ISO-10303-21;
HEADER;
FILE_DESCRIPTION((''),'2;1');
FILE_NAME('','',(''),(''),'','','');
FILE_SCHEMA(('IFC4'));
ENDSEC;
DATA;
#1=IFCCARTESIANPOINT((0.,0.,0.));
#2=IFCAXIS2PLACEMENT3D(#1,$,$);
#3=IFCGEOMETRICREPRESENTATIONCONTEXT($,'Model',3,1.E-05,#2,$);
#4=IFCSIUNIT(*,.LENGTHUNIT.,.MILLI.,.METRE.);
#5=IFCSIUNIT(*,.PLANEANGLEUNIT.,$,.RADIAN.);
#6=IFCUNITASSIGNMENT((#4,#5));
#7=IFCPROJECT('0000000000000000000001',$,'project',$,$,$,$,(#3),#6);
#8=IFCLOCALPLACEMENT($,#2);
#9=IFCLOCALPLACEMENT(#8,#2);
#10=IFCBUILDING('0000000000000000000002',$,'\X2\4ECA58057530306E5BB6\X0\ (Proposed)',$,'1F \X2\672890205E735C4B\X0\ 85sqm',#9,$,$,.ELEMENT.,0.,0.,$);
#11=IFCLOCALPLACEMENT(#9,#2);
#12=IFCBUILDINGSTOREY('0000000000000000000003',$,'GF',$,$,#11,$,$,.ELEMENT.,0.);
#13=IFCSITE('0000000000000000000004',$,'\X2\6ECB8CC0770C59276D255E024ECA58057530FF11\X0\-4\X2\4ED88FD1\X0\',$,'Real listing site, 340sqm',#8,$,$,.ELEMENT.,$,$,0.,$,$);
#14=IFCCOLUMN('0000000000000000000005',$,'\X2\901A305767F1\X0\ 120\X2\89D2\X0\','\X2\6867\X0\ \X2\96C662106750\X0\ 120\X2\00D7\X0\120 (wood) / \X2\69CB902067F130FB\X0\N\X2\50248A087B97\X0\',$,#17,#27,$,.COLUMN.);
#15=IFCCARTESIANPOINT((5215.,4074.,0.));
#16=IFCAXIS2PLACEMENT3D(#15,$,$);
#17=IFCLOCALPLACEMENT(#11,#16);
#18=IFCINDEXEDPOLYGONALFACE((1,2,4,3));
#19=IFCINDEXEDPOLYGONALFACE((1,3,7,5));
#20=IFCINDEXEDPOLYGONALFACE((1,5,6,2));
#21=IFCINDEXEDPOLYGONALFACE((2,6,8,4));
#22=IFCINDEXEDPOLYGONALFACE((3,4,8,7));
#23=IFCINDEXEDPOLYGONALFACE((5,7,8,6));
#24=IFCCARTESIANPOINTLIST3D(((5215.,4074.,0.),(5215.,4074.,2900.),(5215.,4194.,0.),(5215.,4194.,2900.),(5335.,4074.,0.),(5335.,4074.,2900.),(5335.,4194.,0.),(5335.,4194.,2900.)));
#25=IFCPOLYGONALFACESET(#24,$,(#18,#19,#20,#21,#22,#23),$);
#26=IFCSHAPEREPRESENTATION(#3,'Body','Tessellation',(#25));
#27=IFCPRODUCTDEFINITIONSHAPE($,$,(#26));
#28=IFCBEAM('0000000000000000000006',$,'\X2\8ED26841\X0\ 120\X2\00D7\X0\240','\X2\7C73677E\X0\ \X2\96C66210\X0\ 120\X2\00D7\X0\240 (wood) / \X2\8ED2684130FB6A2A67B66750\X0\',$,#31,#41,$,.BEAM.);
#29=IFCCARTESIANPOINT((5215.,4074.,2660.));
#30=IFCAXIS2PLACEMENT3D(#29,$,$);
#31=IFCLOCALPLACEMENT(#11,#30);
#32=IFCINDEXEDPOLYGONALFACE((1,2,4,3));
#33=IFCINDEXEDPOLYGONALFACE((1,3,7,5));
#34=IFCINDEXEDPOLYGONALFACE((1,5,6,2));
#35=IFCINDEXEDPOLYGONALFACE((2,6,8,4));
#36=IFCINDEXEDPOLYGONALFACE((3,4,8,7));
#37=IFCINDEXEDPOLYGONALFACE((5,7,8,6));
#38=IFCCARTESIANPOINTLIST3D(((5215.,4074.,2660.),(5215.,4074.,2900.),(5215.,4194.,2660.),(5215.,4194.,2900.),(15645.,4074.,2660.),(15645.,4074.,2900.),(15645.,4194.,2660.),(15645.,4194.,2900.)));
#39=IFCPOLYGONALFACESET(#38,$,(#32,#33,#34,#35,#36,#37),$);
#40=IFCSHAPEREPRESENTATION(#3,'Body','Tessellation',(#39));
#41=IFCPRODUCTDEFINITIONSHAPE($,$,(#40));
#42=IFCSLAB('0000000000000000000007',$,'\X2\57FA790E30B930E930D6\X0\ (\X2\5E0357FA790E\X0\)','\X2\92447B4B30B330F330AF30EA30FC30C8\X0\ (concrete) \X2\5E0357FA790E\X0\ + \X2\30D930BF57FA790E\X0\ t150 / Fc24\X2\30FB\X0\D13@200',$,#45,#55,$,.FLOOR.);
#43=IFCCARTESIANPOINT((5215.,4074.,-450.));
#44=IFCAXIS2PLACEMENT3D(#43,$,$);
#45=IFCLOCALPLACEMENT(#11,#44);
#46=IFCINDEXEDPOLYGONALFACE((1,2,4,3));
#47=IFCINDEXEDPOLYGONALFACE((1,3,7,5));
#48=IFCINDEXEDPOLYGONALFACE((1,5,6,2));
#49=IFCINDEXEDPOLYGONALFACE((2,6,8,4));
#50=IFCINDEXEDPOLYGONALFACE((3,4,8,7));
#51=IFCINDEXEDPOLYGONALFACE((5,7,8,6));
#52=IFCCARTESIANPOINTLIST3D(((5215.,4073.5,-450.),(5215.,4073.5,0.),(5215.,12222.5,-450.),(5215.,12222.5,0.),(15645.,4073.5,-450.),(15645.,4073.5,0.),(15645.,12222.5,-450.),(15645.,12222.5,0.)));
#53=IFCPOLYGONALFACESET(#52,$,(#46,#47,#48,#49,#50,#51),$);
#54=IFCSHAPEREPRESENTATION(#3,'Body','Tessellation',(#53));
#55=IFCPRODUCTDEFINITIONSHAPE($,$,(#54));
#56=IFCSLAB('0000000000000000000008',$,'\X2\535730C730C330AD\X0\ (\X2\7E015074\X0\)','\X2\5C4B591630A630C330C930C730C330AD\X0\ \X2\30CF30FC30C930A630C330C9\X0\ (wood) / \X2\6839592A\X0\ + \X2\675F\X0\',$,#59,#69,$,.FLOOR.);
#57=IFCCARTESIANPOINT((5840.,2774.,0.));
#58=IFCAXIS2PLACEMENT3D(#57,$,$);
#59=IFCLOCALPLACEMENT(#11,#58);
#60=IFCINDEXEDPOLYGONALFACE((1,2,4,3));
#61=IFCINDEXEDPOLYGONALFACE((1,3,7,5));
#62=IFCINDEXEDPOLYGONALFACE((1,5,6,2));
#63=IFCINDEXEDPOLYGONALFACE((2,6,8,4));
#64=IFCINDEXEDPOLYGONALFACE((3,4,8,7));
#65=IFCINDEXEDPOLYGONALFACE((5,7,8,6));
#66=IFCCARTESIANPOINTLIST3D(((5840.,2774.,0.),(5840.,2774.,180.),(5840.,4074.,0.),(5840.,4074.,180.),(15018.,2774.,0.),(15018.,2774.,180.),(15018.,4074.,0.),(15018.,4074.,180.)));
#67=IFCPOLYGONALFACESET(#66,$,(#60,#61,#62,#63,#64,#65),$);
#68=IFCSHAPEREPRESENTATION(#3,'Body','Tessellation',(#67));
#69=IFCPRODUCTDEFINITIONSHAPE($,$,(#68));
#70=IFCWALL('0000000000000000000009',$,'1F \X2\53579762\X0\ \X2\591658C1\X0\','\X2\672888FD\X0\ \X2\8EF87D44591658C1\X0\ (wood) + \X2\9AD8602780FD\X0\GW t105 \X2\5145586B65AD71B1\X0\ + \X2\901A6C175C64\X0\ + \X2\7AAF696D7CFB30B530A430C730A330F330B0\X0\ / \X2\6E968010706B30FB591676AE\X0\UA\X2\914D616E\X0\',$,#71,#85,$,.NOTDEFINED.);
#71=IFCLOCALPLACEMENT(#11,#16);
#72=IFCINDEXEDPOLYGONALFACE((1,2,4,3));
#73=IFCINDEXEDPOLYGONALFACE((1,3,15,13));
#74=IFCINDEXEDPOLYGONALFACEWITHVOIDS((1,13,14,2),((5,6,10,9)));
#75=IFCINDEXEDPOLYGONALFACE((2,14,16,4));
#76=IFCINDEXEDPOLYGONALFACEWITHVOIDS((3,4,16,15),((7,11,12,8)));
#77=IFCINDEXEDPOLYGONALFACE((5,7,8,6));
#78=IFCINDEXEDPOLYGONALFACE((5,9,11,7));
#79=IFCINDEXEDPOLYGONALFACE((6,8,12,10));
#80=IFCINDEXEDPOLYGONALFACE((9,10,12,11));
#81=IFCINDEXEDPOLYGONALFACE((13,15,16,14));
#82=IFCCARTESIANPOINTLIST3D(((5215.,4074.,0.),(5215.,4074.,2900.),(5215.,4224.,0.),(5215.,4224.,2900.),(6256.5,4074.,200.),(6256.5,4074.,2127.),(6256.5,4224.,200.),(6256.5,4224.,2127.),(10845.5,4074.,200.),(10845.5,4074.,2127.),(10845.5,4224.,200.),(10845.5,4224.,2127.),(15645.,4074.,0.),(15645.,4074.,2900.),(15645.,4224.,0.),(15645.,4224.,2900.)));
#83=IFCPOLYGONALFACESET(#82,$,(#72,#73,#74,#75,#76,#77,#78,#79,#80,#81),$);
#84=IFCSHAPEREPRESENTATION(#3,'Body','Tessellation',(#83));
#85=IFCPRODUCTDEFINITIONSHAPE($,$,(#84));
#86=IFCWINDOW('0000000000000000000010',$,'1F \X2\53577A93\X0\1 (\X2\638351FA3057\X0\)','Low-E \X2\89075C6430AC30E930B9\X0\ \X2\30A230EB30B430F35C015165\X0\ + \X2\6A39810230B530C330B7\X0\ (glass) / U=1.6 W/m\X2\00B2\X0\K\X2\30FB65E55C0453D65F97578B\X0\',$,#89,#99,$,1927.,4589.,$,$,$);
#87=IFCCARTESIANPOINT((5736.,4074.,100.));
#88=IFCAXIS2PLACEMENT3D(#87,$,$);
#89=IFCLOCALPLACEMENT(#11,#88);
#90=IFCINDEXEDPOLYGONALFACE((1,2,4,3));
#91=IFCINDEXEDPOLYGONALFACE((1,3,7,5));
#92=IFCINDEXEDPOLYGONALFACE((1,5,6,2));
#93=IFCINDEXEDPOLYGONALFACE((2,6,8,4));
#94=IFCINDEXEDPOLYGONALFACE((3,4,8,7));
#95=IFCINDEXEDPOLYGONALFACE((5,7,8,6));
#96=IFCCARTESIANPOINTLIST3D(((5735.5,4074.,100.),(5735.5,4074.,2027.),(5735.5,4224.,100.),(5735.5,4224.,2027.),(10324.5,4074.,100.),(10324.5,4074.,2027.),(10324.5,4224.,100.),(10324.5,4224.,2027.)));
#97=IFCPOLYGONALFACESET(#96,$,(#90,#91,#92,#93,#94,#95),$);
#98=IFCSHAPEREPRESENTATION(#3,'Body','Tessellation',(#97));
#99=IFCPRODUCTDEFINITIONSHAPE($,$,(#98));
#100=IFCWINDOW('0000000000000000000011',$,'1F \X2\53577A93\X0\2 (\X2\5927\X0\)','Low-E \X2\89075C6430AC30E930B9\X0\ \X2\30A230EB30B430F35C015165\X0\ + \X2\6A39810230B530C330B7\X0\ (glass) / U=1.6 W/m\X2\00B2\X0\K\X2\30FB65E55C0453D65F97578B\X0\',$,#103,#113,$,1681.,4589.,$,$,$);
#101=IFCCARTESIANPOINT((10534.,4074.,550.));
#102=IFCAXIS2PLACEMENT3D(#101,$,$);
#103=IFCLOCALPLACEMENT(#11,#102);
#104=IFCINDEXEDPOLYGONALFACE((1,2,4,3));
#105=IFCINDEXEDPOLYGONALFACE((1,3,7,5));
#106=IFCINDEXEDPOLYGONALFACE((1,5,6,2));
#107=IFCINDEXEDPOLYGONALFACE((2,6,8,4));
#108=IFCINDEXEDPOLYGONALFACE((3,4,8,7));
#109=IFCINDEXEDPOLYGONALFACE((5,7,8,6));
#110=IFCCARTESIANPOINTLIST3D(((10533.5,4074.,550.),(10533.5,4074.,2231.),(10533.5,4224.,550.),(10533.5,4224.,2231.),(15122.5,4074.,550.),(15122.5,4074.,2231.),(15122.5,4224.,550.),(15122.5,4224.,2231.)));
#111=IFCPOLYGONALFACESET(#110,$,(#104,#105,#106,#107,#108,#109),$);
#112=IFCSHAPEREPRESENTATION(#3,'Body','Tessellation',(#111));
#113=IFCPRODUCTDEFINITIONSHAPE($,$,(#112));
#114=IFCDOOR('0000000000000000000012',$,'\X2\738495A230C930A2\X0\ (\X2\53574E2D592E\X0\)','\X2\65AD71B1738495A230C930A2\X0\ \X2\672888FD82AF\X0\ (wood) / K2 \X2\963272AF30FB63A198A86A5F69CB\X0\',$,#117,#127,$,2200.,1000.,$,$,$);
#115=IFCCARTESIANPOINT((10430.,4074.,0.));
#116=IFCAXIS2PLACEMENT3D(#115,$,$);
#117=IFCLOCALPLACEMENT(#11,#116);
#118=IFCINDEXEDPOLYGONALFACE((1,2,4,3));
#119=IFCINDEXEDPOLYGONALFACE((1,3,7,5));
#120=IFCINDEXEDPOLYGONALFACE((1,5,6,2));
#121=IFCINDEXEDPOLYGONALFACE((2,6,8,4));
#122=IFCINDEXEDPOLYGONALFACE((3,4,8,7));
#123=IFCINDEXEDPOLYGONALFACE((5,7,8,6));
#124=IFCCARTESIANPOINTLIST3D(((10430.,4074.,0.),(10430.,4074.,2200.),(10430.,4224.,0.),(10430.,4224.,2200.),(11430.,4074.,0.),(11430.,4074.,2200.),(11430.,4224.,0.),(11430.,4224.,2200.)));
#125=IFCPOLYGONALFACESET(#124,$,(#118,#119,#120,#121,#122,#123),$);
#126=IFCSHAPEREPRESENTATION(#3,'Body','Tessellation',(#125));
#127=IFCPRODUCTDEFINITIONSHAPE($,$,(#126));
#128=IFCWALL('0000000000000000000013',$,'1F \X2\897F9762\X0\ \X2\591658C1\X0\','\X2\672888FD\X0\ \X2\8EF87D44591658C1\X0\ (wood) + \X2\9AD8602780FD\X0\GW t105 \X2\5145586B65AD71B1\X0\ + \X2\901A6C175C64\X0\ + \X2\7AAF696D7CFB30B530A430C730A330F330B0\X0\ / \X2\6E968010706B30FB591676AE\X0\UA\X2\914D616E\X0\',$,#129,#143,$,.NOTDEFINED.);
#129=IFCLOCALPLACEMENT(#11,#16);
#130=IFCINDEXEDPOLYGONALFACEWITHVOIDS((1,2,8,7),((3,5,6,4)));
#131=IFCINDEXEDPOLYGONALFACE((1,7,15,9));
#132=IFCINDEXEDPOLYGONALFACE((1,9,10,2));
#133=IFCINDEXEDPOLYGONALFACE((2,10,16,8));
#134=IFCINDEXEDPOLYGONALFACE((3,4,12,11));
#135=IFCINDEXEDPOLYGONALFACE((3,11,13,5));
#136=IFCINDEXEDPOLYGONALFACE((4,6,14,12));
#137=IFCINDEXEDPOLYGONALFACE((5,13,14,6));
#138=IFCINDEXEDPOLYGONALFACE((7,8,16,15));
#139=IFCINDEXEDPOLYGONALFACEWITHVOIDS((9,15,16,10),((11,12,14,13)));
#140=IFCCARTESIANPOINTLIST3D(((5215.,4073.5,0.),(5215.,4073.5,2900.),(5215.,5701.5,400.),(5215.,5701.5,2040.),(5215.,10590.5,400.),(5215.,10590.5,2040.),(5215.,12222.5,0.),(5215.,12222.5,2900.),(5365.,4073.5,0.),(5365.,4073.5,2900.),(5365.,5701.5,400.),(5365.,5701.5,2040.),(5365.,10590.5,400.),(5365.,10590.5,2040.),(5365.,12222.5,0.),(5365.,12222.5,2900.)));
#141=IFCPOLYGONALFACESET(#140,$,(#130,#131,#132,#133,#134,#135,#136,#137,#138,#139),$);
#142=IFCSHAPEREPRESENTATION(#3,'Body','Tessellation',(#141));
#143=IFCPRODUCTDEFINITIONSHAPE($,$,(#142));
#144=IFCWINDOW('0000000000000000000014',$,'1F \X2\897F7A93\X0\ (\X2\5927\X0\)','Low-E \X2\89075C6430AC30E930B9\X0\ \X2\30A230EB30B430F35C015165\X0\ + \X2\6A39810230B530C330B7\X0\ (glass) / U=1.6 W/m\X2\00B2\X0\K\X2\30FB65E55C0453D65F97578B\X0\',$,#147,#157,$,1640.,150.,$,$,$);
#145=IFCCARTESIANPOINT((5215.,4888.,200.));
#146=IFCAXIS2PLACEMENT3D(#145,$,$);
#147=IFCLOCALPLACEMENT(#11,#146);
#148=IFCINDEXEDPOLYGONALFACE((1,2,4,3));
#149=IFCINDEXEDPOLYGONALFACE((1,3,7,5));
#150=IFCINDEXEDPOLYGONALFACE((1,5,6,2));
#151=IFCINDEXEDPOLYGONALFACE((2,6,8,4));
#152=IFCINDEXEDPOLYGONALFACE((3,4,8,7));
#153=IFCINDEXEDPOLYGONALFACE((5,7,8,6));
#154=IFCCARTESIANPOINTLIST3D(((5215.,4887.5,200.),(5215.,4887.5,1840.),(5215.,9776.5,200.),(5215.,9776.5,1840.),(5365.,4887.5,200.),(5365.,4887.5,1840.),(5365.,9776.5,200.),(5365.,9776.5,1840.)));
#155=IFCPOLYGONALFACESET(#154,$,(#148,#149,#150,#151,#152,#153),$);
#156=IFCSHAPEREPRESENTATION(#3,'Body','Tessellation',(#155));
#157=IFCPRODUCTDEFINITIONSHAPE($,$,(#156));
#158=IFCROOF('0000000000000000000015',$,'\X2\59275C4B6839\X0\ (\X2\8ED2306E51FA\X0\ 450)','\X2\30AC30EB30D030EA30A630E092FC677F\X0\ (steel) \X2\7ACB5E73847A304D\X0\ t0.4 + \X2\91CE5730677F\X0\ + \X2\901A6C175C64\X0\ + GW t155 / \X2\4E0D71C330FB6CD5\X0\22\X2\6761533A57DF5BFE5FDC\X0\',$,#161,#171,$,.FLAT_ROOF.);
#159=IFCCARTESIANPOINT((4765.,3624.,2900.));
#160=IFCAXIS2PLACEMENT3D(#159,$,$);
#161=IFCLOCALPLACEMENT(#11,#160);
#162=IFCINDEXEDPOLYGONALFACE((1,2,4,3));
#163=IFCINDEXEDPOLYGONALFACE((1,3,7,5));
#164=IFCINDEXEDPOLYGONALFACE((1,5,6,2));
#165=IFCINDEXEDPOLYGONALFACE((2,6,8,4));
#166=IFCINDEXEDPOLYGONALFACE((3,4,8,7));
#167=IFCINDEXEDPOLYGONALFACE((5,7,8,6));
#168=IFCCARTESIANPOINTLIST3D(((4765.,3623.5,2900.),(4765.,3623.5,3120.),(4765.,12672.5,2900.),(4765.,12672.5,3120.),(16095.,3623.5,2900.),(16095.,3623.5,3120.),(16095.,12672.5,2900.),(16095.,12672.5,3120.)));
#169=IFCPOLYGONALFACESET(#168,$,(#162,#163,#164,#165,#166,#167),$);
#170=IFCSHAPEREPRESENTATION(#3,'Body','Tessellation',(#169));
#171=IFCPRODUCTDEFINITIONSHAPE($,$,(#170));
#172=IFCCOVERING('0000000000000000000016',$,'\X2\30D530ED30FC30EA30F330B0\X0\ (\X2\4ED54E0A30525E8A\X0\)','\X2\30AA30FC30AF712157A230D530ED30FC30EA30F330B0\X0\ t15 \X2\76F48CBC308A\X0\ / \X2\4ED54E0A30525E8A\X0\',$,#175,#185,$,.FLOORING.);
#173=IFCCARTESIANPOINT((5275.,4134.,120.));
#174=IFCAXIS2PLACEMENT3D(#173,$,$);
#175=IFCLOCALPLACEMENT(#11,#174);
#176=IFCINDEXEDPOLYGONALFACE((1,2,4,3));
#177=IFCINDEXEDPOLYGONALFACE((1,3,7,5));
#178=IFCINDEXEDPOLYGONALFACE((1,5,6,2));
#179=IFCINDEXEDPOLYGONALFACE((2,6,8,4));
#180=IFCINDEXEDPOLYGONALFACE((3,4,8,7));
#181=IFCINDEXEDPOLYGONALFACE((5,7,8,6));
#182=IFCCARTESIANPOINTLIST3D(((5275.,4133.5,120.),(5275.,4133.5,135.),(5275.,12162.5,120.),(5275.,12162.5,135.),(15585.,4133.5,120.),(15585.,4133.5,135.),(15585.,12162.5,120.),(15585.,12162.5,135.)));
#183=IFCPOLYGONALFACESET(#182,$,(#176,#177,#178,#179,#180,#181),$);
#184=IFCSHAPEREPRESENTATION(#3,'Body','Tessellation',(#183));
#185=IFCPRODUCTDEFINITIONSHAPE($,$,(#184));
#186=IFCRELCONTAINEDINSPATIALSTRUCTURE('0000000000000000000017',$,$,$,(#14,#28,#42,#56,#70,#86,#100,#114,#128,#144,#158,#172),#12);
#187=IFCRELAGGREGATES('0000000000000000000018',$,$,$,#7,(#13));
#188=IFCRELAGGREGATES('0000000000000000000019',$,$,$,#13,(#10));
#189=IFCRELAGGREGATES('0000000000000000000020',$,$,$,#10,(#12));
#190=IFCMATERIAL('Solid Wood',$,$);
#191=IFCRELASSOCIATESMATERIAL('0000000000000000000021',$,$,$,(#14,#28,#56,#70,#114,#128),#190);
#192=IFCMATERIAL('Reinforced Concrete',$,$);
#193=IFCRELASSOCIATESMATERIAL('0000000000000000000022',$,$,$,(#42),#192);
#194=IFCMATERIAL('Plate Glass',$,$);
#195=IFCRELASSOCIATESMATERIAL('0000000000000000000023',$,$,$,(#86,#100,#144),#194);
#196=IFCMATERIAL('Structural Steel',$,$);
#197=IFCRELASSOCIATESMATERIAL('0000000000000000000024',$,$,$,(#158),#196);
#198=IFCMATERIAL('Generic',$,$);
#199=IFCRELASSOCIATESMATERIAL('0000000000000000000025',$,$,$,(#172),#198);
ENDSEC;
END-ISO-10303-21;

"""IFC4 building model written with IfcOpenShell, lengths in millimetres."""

from ifc_helpers import new_model, si_unit, frame, frame_2d, origin, place, context, project, spatial, rectangle, extrude, material, element, fill, save


model = new_model("IFC4")

# Units and contexts
model_context = context("Model", 3, precision=1e-05, world=origin())
ifc_project = project(units=[si_unit("LENGTHUNIT", "METRE", prefix="MILLI"), si_unit("PLANEANGLEUNIT", "RADIAN")], contexts=[model_context])

# Site, building, storey
site_placement = place(None, origin())
site = spatial("IfcSite", under=ifc_project, at=site_placement, Name="滋賀県大津市今堅田１-4付近", ObjectType="Real listing site, 340sqm", CompositionType="ELEMENT", RefElevation=0.0)
building_placement = place(site_placement, origin())
building = spatial("IfcBuilding", under=site, at=building_placement, Name="今堅田の家 (Proposed)", ObjectType="1F 木造平屋 85sqm", CompositionType="ELEMENT", ElevationOfRefHeight=0.0, ElevationOfTerrain=0.0)
storey_placement = place(building_placement, origin())
storey = spatial("IfcBuildingStorey", under=building, at=storey_placement, Name="GF", CompositionType="ELEMENT", Elevation=0.0)

# Column
ifc_material_1 = material(Name="Solid Wood")
column_1_placement = place(storey_placement, frame((5215.0, 4074.0, 0.0)))
element("IfcColumn", 1, at=column_1_placement, inside=storey, material=ifc_material_1, Name="通し柱 120角", Description="桧 集成材 120×120 (wood) / 構造柱・N値計算", PredefinedType="COLUMN", context=model_context, shape_type="SweptSolid", body=[
    extrude(rectangle(XDim=120.0, YDim=120.0, at=frame_2d((60.0, 60.0))), frame((5215.0, 4074.0, 0.0)), (0.0, 0.0, 1.0), 2900.0),
])

# Beam
beam_1_placement = place(storey_placement, frame((5215.0, 4074.0, 2660.0)))
element("IfcBeam", 2, at=beam_1_placement, inside=storey, material=ifc_material_1, Name="軒桁 120×240", Description="米松 集成 120×240 (wood) / 軒桁・横架材", PredefinedType="BEAM", context=model_context, shape_type="SweptSolid", body=[
    extrude(rectangle(XDim=10430.0, YDim=120.0, at=frame_2d((5215.0, 60.0))), frame((5215.0, 4074.0, 2660.0)), (0.0, 0.0, 1.0), 240.0),
])

# Slabs
ifc_material_2 = material(Name="Reinforced Concrete")
slab_1_placement = place(storey_placement, frame((5215.0, 4074.0, -450.0)))
element("IfcSlab", 3, at=slab_1_placement, inside=storey, material=ifc_material_2, Name="基礎スラブ (布基礎)", Description="鉄筋コンクリート (concrete) 布基礎 + ベタ基礎 t150 / Fc24・D13@200", PredefinedType="FLOOR", context=model_context, shape_type="SweptSolid", body=[
    extrude(rectangle(XDim=10430.0, YDim=8149.0, at=frame_2d((5215.0, 4074.0))), frame((5215.0, 4074.0, -450.0)), (0.0, 0.0, 1.0), 450.0),
])
slab_2_placement = place(storey_placement, frame((5840.0, 2774.0, 0.0)))
element("IfcSlab", 4, at=slab_2_placement, inside=storey, material=ifc_material_1, Name="南デッキ (縁側)", Description="屋外ウッドデッキ ハードウッド (wood) / 根太 + 束", PredefinedType="FLOOR", context=model_context, shape_type="SweptSolid", body=[
    extrude(rectangle(XDim=9178.0, YDim=1300.0, at=frame_2d((4589.0, 650.0))), frame((5840.0, 2774.0, 0.0)), (0.0, 0.0, 1.0), 180.0),
])

# Wall, openings, windows, door
wall_1_placement = place(storey_placement, frame((5215.0, 4074.0, 0.0)))
wall_1 = element("IfcWall", 5, at=wall_1_placement, inside=storey, material=ifc_material_1, Name="1F 南面 外壁", Description="木製 軸組外壁 (wood) + 高性能GW t105 充填断熱 + 通気層 + 窯業系サイディング / 準耐火・外皮UA配慮", PredefinedType="NOTDEFINED", context=model_context, shape_type="SweptSolid", body=[
    extrude(rectangle(XDim=10430.0, YDim=150.0, at=frame_2d((5215.0, 75.0))), frame((5215.0, 4074.0, 0.0)), (0.0, 0.0, 1.0), 2900.0),
])
opening_1_placement = place(storey_placement, frame((5736.0, 4074.0, 100.0)))
opening_1 = element("IfcOpeningElement", 6, at=opening_1_placement, cuts=wall_1, PredefinedType="NOTDEFINED", context=model_context, shape_type="SweptSolid", body=[
    extrude(rectangle(XDim=4589.0, YDim=150.0, at=frame_2d((2294.0, 75.0))), frame((5736.0, 4074.0, 100.0)), (0.0, 0.0, 1.0), 1927.0),
])
opening_2_placement = place(storey_placement, frame((10534.0, 4074.0, 550.0)))
opening_2 = element("IfcOpeningElement", 7, at=opening_2_placement, cuts=wall_1, PredefinedType="NOTDEFINED", context=model_context, shape_type="SweptSolid", body=[
    extrude(rectangle(XDim=4589.0, YDim=150.0, at=frame_2d((2294.0, 75.0))), frame((10534.0, 4074.0, 550.0)), (0.0, 0.0, 1.0), 1681.0),
])
opening_3_placement = place(storey_placement, frame((10430.0, 4074.0, 0.0)))
opening_3 = element("IfcOpeningElement", 8, at=opening_3_placement, cuts=wall_1, PredefinedType="NOTDEFINED", context=model_context, shape_type="SweptSolid", body=[
    extrude(rectangle(XDim=1000.0, YDim=150.0, at=frame_2d((500.0, 75.0))), frame((10430.0, 4074.0, 0.0)), (0.0, 0.0, 1.0), 2200.0),
])
ifc_material_3 = material(Name="Plate Glass")
window_1_placement = place(storey_placement, frame((5736.0, 4074.0, 100.0)))
window_1 = element("IfcWindow", 9, at=window_1_placement, inside=storey, material=ifc_material_3, Name="1F 南窓1 (掃出し)", Description="Low-E 複層ガラス アルゴン封入 + 樹脂サッシ (glass) / U=1.6 W/m²K・日射取得型", OverallHeight=1927.0, OverallWidth=4589.0, context=model_context, shape_type="SweptSolid", body=[
    extrude(rectangle(XDim=4589.0, YDim=150.0, at=frame_2d((2294.0, 75.0))), frame((5736.0, 4074.0, 100.0)), (0.0, 0.0, 1.0), 1927.0),
])
fill(opening_1, window_1)
window_2_placement = place(storey_placement, frame((10534.0, 4074.0, 550.0)))
window_2 = element("IfcWindow", 10, at=window_2_placement, inside=storey, material=ifc_material_3, Name="1F 南窓2 (大)", Description="Low-E 複層ガラス アルゴン封入 + 樹脂サッシ (glass) / U=1.6 W/m²K・日射取得型", OverallHeight=1681.0, OverallWidth=4589.0, context=model_context, shape_type="SweptSolid", body=[
    extrude(rectangle(XDim=4589.0, YDim=150.0, at=frame_2d((2294.0, 75.0))), frame((10534.0, 4074.0, 550.0)), (0.0, 0.0, 1.0), 1681.0),
])
fill(opening_2, window_2)
door_placement = place(storey_placement, frame((10430.0, 4074.0, 0.0)))
door = element("IfcDoor", 11, at=door_placement, inside=storey, material=ifc_material_1, Name="玄関ドア (南中央)", Description="断熱玄関ドア 木製芯 (wood) / K2 防犯・採風機構", OverallHeight=2200.0, OverallWidth=1000.0, context=model_context, shape_type="SweptSolid", body=[
    extrude(rectangle(XDim=1000.0, YDim=150.0, at=frame_2d((500.0, 75.0))), frame((10430.0, 4074.0, 0.0)), (0.0, 0.0, 1.0), 2200.0),
])
fill(opening_3, door)

# Wall, opening, window
wall_2_placement = place(storey_placement, frame((5215.0, 4074.0, 0.0)))
wall_2 = element("IfcWall", 12, at=wall_2_placement, inside=storey, material=ifc_material_1, Name="1F 西面 外壁", Description="木製 軸組外壁 (wood) + 高性能GW t105 充填断熱 + 通気層 + 窯業系サイディング / 準耐火・外皮UA配慮", PredefinedType="NOTDEFINED", context=model_context, shape_type="SweptSolid", body=[
    extrude(rectangle(XDim=150.0, YDim=8149.0, at=frame_2d((75.0, 4074.0))), frame((5215.0, 4074.0, 0.0)), (0.0, 0.0, 1.0), 2900.0),
])
opening_4_placement = place(storey_placement, frame((5215.0, 4888.0, 200.0)))
opening_4 = element("IfcOpeningElement", 13, at=opening_4_placement, cuts=wall_2, PredefinedType="NOTDEFINED", context=model_context, shape_type="SweptSolid", body=[
    extrude(rectangle(XDim=150.0, YDim=4889.0, at=frame_2d((75.0, 2444.0))), frame((5215.0, 4888.0, 200.0)), (0.0, 0.0, 1.0), 1640.0),
])
window_3_placement = place(storey_placement, frame((5215.0, 4888.0, 200.0)))
window_3 = element("IfcWindow", 14, at=window_3_placement, inside=storey, material=ifc_material_3, Name="1F 西窓 (大)", Description="Low-E 複層ガラス アルゴン封入 + 樹脂サッシ (glass) / U=1.6 W/m²K・日射取得型", OverallHeight=1640.0, OverallWidth=150.0, context=model_context, shape_type="SweptSolid", body=[
    extrude(rectangle(XDim=150.0, YDim=4889.0, at=frame_2d((75.0, 2444.0))), frame((5215.0, 4888.0, 200.0)), (0.0, 0.0, 1.0), 1640.0),
])
fill(opening_4, window_3)

# Roof
ifc_material_4 = material(Name="Structural Steel")
roof_placement = place(storey_placement, frame((4765.0, 3624.0, 2900.0)))
element("IfcRoof", 15, at=roof_placement, inside=storey, material=ifc_material_4, Name="大屋根 (軒の出 450)", Description="ガルバリウム鋼板 (steel) 立平葺き t0.4 + 野地板 + 通気層 + GW t155 / 不燃・法22条区域対応", PredefinedType="FLAT_ROOF", context=model_context, shape_type="SweptSolid", body=[
    extrude(rectangle(XDim=11330.0, YDim=9049.0, at=frame_2d((5665.0, 4524.0))), frame((4765.0, 3624.0, 2900.0)), (0.0, 0.0, 1.0), 220.0),
])

# Covering
ifc_material_5 = material(Name="Generic")
covering_1_placement = place(storey_placement, frame((5275.0, 4134.0, 120.0)))
element("IfcCovering", 16, at=covering_1_placement, inside=storey, material=ifc_material_5, Name="フローリング (仕上げ床)", Description="オーク無垢フローリング t15 直貼り / 仕上げ床", PredefinedType="FLOORING", context=model_context, shape_type="SweptSolid", body=[
    extrude(rectangle(XDim=10310.0, YDim=8029.0, at=frame_2d((5155.0, 4014.0))), frame((5275.0, 4134.0, 120.0)), (0.0, 0.0, 1.0), 15.0),
])

save(model, "model.ifc")
